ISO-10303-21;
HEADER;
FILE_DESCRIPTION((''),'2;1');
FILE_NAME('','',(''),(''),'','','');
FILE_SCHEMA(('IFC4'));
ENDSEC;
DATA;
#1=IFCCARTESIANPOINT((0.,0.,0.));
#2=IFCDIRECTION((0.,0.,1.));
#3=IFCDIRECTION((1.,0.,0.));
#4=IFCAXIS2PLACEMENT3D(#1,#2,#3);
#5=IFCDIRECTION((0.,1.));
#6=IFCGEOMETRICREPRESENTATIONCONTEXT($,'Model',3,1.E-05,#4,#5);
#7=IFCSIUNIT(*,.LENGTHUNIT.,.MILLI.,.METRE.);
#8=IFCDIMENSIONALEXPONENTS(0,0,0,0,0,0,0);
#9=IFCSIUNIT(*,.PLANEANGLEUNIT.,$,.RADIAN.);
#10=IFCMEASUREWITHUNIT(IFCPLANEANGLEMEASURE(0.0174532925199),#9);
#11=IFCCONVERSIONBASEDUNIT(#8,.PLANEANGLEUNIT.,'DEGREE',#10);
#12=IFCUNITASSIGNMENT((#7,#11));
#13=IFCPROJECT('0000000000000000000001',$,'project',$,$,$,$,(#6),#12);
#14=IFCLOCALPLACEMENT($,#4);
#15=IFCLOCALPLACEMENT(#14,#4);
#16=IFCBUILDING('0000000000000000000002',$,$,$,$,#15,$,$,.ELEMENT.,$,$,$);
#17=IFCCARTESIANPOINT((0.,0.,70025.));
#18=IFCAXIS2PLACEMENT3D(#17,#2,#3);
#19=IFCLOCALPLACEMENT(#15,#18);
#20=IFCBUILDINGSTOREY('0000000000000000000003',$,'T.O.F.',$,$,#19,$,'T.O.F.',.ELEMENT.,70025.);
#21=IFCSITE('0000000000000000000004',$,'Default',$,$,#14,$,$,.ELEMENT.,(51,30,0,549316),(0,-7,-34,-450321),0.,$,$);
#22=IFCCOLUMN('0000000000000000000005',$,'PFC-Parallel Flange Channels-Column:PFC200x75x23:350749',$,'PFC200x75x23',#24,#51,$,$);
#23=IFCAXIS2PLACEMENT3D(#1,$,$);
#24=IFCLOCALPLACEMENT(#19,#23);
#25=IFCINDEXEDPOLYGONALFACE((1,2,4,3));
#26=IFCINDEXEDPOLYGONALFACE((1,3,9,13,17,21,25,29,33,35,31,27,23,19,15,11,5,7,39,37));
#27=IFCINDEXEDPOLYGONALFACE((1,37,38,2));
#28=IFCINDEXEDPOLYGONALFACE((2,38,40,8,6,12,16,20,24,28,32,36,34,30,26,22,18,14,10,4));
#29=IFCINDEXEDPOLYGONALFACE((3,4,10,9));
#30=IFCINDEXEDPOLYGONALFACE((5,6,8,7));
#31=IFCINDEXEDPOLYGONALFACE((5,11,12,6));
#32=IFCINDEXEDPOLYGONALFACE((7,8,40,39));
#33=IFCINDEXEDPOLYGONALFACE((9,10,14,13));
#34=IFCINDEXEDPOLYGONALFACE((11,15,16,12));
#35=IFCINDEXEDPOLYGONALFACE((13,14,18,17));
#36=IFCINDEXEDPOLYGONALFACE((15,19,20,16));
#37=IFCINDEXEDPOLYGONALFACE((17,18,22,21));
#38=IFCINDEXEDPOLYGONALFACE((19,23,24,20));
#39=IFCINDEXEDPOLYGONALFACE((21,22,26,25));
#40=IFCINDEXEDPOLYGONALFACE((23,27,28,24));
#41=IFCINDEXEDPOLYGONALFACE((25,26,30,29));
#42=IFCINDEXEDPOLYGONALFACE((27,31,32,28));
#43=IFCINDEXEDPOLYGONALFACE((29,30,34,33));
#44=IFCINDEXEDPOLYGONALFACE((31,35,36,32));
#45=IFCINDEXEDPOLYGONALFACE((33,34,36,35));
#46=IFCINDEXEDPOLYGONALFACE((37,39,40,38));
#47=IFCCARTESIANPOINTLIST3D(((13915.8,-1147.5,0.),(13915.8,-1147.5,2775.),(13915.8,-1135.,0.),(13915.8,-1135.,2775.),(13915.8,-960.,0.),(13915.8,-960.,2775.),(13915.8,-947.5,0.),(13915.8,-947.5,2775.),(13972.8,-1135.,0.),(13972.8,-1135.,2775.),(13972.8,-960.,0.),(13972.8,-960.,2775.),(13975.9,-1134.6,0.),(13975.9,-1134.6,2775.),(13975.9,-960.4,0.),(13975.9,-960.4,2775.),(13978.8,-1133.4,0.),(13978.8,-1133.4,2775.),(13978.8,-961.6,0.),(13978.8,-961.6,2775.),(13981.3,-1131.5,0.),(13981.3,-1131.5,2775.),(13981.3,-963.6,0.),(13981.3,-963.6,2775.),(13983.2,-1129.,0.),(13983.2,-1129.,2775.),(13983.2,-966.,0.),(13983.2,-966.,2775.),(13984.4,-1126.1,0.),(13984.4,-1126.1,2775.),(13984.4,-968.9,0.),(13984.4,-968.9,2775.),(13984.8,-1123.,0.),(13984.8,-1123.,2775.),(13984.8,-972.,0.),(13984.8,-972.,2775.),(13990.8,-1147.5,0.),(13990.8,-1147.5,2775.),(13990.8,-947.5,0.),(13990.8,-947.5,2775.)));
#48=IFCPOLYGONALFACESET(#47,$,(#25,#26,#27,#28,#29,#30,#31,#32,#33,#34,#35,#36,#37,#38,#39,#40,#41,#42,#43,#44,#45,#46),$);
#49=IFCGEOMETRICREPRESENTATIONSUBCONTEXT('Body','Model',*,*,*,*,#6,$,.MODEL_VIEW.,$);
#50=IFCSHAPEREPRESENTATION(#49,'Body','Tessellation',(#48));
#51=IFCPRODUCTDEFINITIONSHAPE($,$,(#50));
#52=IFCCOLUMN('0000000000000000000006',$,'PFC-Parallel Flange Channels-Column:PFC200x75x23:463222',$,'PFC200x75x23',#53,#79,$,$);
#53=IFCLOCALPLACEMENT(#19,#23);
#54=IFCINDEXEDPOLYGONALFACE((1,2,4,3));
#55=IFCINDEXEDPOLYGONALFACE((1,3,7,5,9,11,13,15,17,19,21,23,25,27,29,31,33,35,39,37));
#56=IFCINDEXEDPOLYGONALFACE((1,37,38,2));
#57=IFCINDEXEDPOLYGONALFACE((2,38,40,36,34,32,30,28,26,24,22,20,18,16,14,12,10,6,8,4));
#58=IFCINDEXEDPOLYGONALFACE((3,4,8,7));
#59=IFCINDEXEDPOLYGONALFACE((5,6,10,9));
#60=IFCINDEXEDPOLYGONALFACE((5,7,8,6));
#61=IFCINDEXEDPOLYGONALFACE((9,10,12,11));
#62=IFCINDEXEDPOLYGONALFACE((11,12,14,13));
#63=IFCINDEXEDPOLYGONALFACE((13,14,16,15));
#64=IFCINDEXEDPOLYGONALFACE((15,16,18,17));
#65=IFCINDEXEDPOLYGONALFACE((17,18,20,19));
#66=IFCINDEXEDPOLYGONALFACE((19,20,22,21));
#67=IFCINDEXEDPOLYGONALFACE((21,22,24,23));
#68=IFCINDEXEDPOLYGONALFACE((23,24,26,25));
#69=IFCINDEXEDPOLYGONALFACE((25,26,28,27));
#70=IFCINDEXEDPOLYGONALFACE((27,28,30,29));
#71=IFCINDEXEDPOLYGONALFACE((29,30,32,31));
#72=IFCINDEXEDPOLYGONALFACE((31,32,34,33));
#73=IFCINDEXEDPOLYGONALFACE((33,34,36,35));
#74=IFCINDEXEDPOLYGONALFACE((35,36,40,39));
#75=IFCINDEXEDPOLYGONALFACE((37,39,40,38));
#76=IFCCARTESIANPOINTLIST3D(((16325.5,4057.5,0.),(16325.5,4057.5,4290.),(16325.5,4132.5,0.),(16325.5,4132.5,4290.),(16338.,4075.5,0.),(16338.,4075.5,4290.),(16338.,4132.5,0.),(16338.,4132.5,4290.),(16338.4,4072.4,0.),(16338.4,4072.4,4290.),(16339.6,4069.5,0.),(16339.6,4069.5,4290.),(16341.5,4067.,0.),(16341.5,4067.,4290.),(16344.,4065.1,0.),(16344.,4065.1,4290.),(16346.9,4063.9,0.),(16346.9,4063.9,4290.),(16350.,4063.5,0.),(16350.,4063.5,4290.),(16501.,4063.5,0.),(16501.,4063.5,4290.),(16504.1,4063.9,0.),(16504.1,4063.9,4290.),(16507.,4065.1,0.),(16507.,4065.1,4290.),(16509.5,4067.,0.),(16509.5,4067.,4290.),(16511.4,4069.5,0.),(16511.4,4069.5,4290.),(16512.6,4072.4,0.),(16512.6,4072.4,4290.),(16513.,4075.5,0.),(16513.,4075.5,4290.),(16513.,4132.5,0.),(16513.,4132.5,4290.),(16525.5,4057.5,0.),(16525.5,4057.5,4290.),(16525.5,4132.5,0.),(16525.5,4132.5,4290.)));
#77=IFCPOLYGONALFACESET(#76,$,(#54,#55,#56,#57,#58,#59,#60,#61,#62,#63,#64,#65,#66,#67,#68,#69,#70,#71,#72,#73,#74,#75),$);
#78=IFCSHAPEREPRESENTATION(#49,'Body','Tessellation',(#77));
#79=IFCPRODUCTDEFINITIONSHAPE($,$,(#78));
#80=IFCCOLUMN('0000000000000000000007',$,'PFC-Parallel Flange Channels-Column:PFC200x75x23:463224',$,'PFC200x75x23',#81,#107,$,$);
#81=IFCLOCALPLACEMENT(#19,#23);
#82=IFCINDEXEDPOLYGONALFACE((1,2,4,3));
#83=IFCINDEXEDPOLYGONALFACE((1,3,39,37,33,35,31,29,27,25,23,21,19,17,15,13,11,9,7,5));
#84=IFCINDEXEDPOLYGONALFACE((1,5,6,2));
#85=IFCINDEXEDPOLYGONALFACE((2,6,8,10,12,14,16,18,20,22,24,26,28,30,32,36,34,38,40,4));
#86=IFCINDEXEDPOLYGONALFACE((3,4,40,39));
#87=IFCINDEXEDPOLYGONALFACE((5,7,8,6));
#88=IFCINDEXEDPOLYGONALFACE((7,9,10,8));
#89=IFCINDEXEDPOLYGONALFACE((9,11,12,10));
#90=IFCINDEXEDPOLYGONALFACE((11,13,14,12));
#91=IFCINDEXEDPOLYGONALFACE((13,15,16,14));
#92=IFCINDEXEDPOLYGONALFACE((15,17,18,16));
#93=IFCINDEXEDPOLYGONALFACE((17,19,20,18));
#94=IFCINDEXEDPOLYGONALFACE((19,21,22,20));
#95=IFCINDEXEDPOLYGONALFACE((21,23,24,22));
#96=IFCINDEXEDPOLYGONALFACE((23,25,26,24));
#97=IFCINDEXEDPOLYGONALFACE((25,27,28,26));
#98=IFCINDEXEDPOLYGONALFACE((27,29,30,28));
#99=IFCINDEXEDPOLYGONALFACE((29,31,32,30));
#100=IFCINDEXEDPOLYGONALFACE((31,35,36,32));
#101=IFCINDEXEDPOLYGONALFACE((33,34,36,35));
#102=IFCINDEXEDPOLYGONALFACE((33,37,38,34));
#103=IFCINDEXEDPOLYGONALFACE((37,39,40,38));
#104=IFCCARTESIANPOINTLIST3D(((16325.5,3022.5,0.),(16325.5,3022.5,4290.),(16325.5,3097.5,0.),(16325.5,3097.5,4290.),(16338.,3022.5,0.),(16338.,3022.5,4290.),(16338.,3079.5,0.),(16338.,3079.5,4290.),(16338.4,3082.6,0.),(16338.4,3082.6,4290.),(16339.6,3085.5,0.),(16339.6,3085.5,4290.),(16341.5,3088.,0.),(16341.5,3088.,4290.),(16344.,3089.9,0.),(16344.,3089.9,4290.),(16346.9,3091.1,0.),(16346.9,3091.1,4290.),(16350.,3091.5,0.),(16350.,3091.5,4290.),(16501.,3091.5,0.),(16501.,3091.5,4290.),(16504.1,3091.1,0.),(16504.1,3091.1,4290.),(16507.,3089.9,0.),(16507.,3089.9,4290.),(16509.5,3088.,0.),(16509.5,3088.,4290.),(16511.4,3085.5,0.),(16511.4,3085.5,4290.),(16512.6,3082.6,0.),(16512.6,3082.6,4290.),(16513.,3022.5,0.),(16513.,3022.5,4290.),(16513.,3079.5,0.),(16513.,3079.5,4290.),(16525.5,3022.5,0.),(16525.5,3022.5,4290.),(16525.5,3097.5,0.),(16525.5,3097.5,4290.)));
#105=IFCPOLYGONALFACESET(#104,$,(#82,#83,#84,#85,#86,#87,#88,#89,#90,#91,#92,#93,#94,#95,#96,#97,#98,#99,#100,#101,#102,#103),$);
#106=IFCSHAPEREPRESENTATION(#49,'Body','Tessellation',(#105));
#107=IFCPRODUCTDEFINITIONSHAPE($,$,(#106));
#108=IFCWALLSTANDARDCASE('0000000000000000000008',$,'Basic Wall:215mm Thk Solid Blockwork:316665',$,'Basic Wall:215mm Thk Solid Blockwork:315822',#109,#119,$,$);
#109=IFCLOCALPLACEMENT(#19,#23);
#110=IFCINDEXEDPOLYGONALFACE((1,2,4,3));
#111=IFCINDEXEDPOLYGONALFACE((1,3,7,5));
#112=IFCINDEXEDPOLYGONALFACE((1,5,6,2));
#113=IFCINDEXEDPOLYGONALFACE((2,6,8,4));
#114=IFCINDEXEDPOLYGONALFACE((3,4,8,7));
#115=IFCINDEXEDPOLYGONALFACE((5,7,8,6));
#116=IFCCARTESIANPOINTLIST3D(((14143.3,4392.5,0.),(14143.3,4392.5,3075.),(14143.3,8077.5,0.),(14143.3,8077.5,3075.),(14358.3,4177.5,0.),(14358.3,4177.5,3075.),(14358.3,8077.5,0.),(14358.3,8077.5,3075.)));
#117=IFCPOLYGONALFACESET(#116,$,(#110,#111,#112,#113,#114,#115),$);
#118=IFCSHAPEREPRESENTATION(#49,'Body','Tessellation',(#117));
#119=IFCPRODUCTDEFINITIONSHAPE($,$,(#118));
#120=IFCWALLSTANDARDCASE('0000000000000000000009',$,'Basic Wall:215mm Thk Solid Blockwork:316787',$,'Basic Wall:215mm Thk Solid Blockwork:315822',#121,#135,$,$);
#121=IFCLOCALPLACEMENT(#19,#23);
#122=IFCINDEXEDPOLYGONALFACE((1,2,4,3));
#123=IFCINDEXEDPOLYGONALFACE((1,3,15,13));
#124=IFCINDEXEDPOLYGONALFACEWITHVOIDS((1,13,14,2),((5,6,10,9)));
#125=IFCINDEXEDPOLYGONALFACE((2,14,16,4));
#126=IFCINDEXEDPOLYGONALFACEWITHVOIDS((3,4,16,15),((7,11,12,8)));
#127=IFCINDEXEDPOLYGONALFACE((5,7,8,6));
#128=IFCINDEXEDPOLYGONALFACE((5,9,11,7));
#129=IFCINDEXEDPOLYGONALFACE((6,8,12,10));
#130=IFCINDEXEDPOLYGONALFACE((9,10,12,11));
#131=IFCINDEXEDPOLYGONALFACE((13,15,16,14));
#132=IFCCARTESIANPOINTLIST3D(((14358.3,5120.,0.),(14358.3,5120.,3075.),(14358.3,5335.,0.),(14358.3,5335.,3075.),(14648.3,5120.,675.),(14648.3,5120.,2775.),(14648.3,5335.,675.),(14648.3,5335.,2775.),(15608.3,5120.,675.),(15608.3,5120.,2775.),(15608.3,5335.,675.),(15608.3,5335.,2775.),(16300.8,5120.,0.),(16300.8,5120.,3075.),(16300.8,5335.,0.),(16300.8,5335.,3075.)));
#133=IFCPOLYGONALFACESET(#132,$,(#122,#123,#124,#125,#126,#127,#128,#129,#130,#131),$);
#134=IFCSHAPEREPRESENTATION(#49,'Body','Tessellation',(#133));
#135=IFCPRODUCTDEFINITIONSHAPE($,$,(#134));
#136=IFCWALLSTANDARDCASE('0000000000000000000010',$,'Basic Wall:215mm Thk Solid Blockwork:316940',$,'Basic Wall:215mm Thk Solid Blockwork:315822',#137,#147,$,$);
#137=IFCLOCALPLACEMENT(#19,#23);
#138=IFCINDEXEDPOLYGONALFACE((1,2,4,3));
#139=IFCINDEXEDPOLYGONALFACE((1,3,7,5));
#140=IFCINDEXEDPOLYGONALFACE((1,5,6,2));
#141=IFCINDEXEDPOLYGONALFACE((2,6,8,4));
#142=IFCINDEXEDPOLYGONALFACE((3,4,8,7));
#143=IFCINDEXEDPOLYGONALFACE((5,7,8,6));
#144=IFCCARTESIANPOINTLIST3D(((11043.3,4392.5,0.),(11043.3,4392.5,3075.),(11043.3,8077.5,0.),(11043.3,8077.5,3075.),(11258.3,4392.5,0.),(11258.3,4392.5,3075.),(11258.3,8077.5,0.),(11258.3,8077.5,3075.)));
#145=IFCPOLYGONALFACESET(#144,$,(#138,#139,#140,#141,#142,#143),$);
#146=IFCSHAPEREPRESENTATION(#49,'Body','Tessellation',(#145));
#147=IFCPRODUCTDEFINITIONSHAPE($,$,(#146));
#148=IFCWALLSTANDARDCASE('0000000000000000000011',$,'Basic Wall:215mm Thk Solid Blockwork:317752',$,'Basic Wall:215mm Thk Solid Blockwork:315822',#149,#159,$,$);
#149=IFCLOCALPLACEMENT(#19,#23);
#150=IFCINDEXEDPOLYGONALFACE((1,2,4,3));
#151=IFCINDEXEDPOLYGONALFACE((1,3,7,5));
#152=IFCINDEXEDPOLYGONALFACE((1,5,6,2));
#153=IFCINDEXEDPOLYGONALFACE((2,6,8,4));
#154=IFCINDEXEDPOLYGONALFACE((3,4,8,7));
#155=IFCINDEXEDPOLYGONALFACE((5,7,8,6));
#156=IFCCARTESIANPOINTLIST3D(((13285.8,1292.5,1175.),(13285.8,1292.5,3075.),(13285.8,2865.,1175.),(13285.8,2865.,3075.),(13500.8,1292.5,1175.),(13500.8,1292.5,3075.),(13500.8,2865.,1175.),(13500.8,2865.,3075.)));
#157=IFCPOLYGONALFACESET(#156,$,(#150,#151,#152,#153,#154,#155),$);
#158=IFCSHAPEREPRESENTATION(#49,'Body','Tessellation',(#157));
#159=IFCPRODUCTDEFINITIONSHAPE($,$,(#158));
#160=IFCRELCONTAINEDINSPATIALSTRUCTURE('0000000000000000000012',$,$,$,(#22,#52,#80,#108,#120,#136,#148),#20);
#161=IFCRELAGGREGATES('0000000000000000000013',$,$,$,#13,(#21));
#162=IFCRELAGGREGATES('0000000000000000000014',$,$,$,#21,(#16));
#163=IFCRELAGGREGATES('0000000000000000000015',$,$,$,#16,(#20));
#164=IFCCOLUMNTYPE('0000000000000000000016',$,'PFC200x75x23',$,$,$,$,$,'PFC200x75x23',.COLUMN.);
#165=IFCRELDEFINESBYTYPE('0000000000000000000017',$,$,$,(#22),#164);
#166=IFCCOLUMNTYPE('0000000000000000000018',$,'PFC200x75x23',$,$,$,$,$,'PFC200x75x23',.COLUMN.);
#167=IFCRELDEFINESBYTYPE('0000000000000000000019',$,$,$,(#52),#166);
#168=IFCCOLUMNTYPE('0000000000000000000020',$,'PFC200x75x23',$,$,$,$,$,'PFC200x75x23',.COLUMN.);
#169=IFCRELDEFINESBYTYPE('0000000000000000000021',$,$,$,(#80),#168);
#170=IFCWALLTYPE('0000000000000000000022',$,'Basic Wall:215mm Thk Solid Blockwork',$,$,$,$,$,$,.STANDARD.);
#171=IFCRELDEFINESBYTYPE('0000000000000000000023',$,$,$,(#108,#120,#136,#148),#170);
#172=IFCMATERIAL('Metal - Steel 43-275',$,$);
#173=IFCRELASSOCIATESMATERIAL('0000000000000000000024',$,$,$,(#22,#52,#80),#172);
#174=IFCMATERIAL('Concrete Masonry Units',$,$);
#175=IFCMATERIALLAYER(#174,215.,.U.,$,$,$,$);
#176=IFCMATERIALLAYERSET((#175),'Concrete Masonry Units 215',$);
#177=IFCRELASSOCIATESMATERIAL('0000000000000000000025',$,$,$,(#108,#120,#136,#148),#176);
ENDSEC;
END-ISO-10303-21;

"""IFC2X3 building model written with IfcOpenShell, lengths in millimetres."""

from ifc_helpers import new_model, entity, si_unit, converted_unit, point, direction, frame, frame_2d, origin_with_axes, place, context, subcontext, project, spatial, polyline, circle_curve, parameter, trimmed, segment, composite_curve, outline, extrude, material, layer, layer_set, layer_usage, type_object, element, save


model = new_model("IFC2X3")

# Units and contexts
model_context = context("Model", 3, precision=1e-05, world=origin_with_axes(), true_north=direction((0.0, 1.0)))
body_context = subcontext(model_context, "Body", "Model", "MODEL_VIEW")
ifc_project = project(units=[si_unit("LENGTHUNIT", "METRE", prefix="MILLI"), converted_unit("PLANEANGLEUNIT", "DEGREE", entity("IfcPlaneAngleMeasure", 0.0174532925199), si_unit("PLANEANGLEUNIT", "RADIAN"), dimensions=[0, 0, 0, 0, 0, 0, 0])], contexts=[model_context])

# Site, building, storey
site_placement = place(None, origin_with_axes())
site = spatial("IfcSite", under=ifc_project, at=site_placement, Name="Default", CompositionType="ELEMENT", RefLatitude=(51, 30, 0, 549316), RefLongitude=(0, -7, -34, -450321), RefElevation=0.0)
building_placement = place(site_placement, origin_with_axes())
building = spatial("IfcBuilding", under=site, at=building_placement, CompositionType="ELEMENT")
storey_placement = place(building_placement, frame((0.0, 0.0, 70025.0), z_axis=(0.0, 0.0, 1.0), x_axis=(1.0, 0.0, 0.0)))
storey = spatial("IfcBuildingStorey", under=building, at=storey_placement, Name="T.O.F.", LongName="T.O.F.", CompositionType="ELEMENT", Elevation=70025.0)

# Columns
ifc_material_1 = material(Name="Metal - Steel 43-275")
column_type_1 = type_object("IfcColumnType", Name="PFC200x75x23", ElementType="PFC200x75x23", PredefinedType="COLUMN")
for number, where, z_axis, x_axis, name in (
    (1, (13956.0, -1047.5, 0.0), (0.0, 0.0, 1.0), (0.0, 1.0, 0.0), "PFC-Parallel Flange Channels-Column:PFC200x75x23:350749"),
):
    element("IfcColumn", number, at=place(storey_placement, frame(where, z_axis=z_axis, x_axis=x_axis)), inside=storey, type_object=column_type_1, material=ifc_material_1, Name=name, ObjectType="PFC200x75x23", context=body_context, shape_type="SweptSolid", body=[
        extrude(outline(composite_curve([segment(polyline([(-100.0, -34.8), (100.0, -34.8), (100.0, 40.2), (87.5, 40.2), (87.5, -16.8)]), True, "CONTINUOUS"), segment(trimmed(circle_curve(frame_2d((75.5, -16.8), x_axis=(0.0, -1.0)), 12.0), [point((87.5, -16.8)), parameter(90.0)], [point((75.5, -28.8)), parameter(0.0)], False, "CARTESIAN"), True, "CONTINUOUS"), segment(polyline([(75.5, -28.8), (-75.5, -28.8)]), True, "CONTINUOUS"), segment(trimmed(circle_curve(frame_2d((-75.5, -16.8), x_axis=(-1.0, 0.0)), 12.0), [point((-75.5, -28.8)), parameter(90.0)], [point((-87.5, -16.8)), parameter(0.0)], False, "CARTESIAN"), True, "CONTINUOUS"), segment(polyline([(-87.5, -16.8), (-87.5, 40.2), (-100.0, 40.2), (-100.0, -34.8)]), True, "CONTINUOUS")], self_intersect=False)), origin_with_axes(), (0.0, 0.0, 1.0), 2775.0),
    ])
column_type_2 = type_object("IfcColumnType", Name="PFC200x75x23", ElementType="PFC200x75x23", PredefinedType="COLUMN")
column_1_placement = place(storey_placement, frame((16425.5, 4092.3, 0.0), z_axis=(0.0, 0.0, 1.0), x_axis=(1.0, 0.0, 0.0)))
element("IfcColumn", 2, at=column_1_placement, inside=storey, type_object=column_type_2, material=ifc_material_1, Name="PFC-Parallel Flange Channels-Column:PFC200x75x23:463222", ObjectType="PFC200x75x23", context=body_context, shape_type="SweptSolid", body=[
    extrude(outline(composite_curve([segment(polyline([(-100.0, -34.8), (100.0, -34.8), (100.0, 40.2), (87.5, 40.2), (87.5, -16.8)]), True, "CONTINUOUS"), segment(trimmed(circle_curve(frame_2d((75.5, -16.8), x_axis=(0.0, -1.0)), 12.0), [point((87.5, -16.8)), parameter(90.0)], [point((75.5, -28.8)), parameter(0.0)], False, "CARTESIAN"), True, "CONTINUOUS"), segment(polyline([(75.5, -28.8), (-75.5, -28.8)]), True, "CONTINUOUS"), segment(trimmed(circle_curve(frame_2d((-75.5, -16.8), x_axis=(-1.0, 0.0)), 12.0), [point((-75.5, -28.8)), parameter(90.0)], [point((-87.5, -16.8)), parameter(0.0)], False, "CARTESIAN"), True, "CONTINUOUS"), segment(polyline([(-87.5, -16.8), (-87.5, 40.2), (-100.0, 40.2), (-100.0, -34.8)]), True, "CONTINUOUS")], self_intersect=False)), origin_with_axes(), (0.0, 0.0, 1.0), 4290.0),
])
column_type_3 = type_object("IfcColumnType", Name="PFC200x75x23", ElementType="PFC200x75x23", PredefinedType="COLUMN")
column_2_placement = place(storey_placement, frame((16425.5, 3062.7, 0.0), z_axis=(0.0, 0.0, 1.0), x_axis=(-1.0, 0.0, 0.0)))
element("IfcColumn", 3, at=column_2_placement, inside=storey, type_object=column_type_3, material=ifc_material_1, Name="PFC-Parallel Flange Channels-Column:PFC200x75x23:463224", ObjectType="PFC200x75x23", context=body_context, shape_type="SweptSolid", body=[
    extrude(outline(composite_curve([segment(polyline([(-100.0, -34.8), (100.0, -34.8), (100.0, 40.2), (87.5, 40.2), (87.5, -16.8)]), True, "CONTINUOUS"), segment(trimmed(circle_curve(frame_2d((75.5, -16.8), x_axis=(0.0, -1.0)), 12.0), [point((87.5, -16.8)), parameter(90.0)], [point((75.5, -28.8)), parameter(0.0)], False, "CARTESIAN"), True, "CONTINUOUS"), segment(polyline([(75.5, -28.8), (-75.5, -28.8)]), True, "CONTINUOUS"), segment(trimmed(circle_curve(frame_2d((-75.5, -16.8), x_axis=(-1.0, 0.0)), 12.0), [point((-75.5, -28.8)), parameter(90.0)], [point((-87.5, -16.8)), parameter(0.0)], False, "CARTESIAN"), True, "CONTINUOUS"), segment(polyline([(-87.5, -16.8), (-87.5, 40.2), (-100.0, 40.2), (-100.0, -34.8)]), True, "CONTINUOUS")], self_intersect=False)), origin_with_axes(), (0.0, 0.0, 1.0), 4290.0),
])

# Wall
ifc_material_2 = material(Name="Concrete Masonry Units")
ifc_layer_1 = layer(ifc_material_2, 215.0, ventilated="UNKNOWN")
ifc_layer_set_1 = layer_set([ifc_layer_1], Name="Concrete Masonry Units 215")
ifc_layer_usage_1 = layer_usage(ifc_layer_set_1, "AXIS2", "POSITIVE", -107.5)
wall_type_1 = type_object("IfcWallType", Name="Basic Wall:215mm Thk Solid Blockwork", PredefinedType="STANDARD")
wall_1_placement = place(storey_placement, frame((14250.8, 4285.0, 0.0), z_axis=(0.0, 0.0, 1.0), x_axis=(0.0, 1.0, 0.0)))
element("IfcWallStandardCase", 4, at=wall_1_placement, inside=storey, type_object=wall_type_1, material=ifc_layer_usage_1, Name="Basic Wall:215mm Thk Solid Blockwork:316665", ObjectType="Basic Wall:215mm Thk Solid Blockwork:315822", context=body_context, shape_type="SweptSolid", body=[
    extrude(outline(polyline([(-107.5, -107.5), (3792.5, -107.5), (3792.5, 107.5), (107.5, 107.5), (-107.5, -107.5)])), origin_with_axes(), (0.0, 0.0, 1.0), 3075.0),
])

# Wall, opening
ifc_layer_usage_2 = layer_usage(ifc_layer_set_1, "AXIS2", "POSITIVE", -107.5)
wall_2_placement = place(storey_placement, frame((14250.8, 5227.5, 0.0), z_axis=(0.0, 0.0, 1.0), x_axis=(1.0, 0.0, 0.0)))
wall_2 = element("IfcWallStandardCase", 5, at=wall_2_placement, inside=storey, type_object=wall_type_1, material=ifc_layer_usage_2, Name="Basic Wall:215mm Thk Solid Blockwork:316787", ObjectType="Basic Wall:215mm Thk Solid Blockwork:315822", context=body_context, shape_type="SweptSolid", body=[
    extrude(outline(polyline([(107.5, -107.5), (2050.0, -107.5), (2050.0, 107.5), (107.5, 107.5), (107.5, -107.5)])), origin_with_axes(), (0.0, 0.0, 1.0), 3075.0),
])
opening_1_placement = place(wall_2_placement, frame((877.5, 0.0, 675.0), z_axis=(0.0, 0.0, 1.0), x_axis=(1.0, 0.0, 0.0)))
element("IfcOpeningElement", 6, at=opening_1_placement, cuts=wall_2, context=body_context, shape_type="SweptSolid", body=[
    extrude(outline(polyline([(480.0, 0.0), (-480.0, 0.0), (-480.0, -2100.0), (480.0, -2100.0), (480.0, 0.0)])), frame((0.0, -107.5, 0.0), z_axis=(0.0, -1.0, 0.0), x_axis=(-1.0, 0.0, 0.0)), (0.0, 0.0, -1.0), 215.0),
])

# Walls
ifc_layer_usage_3 = layer_usage(ifc_layer_set_1, "AXIS2", "POSITIVE", -107.5)
wall_3_placement = place(storey_placement, frame((11150.8, 4285.0, 0.0), z_axis=(0.0, 0.0, 1.0), x_axis=(0.0, 1.0, 0.0)))
element("IfcWallStandardCase", 7, at=wall_3_placement, inside=storey, type_object=wall_type_1, material=ifc_layer_usage_3, Name="Basic Wall:215mm Thk Solid Blockwork:316940", ObjectType="Basic Wall:215mm Thk Solid Blockwork:315822", context=body_context, shape_type="SweptSolid", body=[
    extrude(outline(polyline([(107.5, -107.5), (3792.5, -107.5), (3792.5, 107.5), (107.5, 107.5), (107.5, -107.5)])), origin_with_axes(), (0.0, 0.0, 1.0), 3075.0),
])
ifc_layer_usage_4 = layer_usage(ifc_layer_set_1, "AXIS2", "POSITIVE", -107.5)
wall_4_placement = place(storey_placement, frame((13393.3, 2865.0, 1175.0), z_axis=(0.0, 0.0, 1.0), x_axis=(0.0, -1.0, 0.0)))
element("IfcWallStandardCase", 8, at=wall_4_placement, inside=storey, type_object=wall_type_1, material=ifc_layer_usage_4, Name="Basic Wall:215mm Thk Solid Blockwork:317752", ObjectType="Basic Wall:215mm Thk Solid Blockwork:315822", context=body_context, shape_type="SweptSolid", body=[
    extrude(outline(polyline([(0.0, -107.5), (1572.5, -107.5), (1572.5, 107.5), (0.0, 107.5), (0.0, -107.5)])), origin_with_axes(), (0.0, 0.0, 1.0), 1900.0),
])

save(model, "model.ifc")
